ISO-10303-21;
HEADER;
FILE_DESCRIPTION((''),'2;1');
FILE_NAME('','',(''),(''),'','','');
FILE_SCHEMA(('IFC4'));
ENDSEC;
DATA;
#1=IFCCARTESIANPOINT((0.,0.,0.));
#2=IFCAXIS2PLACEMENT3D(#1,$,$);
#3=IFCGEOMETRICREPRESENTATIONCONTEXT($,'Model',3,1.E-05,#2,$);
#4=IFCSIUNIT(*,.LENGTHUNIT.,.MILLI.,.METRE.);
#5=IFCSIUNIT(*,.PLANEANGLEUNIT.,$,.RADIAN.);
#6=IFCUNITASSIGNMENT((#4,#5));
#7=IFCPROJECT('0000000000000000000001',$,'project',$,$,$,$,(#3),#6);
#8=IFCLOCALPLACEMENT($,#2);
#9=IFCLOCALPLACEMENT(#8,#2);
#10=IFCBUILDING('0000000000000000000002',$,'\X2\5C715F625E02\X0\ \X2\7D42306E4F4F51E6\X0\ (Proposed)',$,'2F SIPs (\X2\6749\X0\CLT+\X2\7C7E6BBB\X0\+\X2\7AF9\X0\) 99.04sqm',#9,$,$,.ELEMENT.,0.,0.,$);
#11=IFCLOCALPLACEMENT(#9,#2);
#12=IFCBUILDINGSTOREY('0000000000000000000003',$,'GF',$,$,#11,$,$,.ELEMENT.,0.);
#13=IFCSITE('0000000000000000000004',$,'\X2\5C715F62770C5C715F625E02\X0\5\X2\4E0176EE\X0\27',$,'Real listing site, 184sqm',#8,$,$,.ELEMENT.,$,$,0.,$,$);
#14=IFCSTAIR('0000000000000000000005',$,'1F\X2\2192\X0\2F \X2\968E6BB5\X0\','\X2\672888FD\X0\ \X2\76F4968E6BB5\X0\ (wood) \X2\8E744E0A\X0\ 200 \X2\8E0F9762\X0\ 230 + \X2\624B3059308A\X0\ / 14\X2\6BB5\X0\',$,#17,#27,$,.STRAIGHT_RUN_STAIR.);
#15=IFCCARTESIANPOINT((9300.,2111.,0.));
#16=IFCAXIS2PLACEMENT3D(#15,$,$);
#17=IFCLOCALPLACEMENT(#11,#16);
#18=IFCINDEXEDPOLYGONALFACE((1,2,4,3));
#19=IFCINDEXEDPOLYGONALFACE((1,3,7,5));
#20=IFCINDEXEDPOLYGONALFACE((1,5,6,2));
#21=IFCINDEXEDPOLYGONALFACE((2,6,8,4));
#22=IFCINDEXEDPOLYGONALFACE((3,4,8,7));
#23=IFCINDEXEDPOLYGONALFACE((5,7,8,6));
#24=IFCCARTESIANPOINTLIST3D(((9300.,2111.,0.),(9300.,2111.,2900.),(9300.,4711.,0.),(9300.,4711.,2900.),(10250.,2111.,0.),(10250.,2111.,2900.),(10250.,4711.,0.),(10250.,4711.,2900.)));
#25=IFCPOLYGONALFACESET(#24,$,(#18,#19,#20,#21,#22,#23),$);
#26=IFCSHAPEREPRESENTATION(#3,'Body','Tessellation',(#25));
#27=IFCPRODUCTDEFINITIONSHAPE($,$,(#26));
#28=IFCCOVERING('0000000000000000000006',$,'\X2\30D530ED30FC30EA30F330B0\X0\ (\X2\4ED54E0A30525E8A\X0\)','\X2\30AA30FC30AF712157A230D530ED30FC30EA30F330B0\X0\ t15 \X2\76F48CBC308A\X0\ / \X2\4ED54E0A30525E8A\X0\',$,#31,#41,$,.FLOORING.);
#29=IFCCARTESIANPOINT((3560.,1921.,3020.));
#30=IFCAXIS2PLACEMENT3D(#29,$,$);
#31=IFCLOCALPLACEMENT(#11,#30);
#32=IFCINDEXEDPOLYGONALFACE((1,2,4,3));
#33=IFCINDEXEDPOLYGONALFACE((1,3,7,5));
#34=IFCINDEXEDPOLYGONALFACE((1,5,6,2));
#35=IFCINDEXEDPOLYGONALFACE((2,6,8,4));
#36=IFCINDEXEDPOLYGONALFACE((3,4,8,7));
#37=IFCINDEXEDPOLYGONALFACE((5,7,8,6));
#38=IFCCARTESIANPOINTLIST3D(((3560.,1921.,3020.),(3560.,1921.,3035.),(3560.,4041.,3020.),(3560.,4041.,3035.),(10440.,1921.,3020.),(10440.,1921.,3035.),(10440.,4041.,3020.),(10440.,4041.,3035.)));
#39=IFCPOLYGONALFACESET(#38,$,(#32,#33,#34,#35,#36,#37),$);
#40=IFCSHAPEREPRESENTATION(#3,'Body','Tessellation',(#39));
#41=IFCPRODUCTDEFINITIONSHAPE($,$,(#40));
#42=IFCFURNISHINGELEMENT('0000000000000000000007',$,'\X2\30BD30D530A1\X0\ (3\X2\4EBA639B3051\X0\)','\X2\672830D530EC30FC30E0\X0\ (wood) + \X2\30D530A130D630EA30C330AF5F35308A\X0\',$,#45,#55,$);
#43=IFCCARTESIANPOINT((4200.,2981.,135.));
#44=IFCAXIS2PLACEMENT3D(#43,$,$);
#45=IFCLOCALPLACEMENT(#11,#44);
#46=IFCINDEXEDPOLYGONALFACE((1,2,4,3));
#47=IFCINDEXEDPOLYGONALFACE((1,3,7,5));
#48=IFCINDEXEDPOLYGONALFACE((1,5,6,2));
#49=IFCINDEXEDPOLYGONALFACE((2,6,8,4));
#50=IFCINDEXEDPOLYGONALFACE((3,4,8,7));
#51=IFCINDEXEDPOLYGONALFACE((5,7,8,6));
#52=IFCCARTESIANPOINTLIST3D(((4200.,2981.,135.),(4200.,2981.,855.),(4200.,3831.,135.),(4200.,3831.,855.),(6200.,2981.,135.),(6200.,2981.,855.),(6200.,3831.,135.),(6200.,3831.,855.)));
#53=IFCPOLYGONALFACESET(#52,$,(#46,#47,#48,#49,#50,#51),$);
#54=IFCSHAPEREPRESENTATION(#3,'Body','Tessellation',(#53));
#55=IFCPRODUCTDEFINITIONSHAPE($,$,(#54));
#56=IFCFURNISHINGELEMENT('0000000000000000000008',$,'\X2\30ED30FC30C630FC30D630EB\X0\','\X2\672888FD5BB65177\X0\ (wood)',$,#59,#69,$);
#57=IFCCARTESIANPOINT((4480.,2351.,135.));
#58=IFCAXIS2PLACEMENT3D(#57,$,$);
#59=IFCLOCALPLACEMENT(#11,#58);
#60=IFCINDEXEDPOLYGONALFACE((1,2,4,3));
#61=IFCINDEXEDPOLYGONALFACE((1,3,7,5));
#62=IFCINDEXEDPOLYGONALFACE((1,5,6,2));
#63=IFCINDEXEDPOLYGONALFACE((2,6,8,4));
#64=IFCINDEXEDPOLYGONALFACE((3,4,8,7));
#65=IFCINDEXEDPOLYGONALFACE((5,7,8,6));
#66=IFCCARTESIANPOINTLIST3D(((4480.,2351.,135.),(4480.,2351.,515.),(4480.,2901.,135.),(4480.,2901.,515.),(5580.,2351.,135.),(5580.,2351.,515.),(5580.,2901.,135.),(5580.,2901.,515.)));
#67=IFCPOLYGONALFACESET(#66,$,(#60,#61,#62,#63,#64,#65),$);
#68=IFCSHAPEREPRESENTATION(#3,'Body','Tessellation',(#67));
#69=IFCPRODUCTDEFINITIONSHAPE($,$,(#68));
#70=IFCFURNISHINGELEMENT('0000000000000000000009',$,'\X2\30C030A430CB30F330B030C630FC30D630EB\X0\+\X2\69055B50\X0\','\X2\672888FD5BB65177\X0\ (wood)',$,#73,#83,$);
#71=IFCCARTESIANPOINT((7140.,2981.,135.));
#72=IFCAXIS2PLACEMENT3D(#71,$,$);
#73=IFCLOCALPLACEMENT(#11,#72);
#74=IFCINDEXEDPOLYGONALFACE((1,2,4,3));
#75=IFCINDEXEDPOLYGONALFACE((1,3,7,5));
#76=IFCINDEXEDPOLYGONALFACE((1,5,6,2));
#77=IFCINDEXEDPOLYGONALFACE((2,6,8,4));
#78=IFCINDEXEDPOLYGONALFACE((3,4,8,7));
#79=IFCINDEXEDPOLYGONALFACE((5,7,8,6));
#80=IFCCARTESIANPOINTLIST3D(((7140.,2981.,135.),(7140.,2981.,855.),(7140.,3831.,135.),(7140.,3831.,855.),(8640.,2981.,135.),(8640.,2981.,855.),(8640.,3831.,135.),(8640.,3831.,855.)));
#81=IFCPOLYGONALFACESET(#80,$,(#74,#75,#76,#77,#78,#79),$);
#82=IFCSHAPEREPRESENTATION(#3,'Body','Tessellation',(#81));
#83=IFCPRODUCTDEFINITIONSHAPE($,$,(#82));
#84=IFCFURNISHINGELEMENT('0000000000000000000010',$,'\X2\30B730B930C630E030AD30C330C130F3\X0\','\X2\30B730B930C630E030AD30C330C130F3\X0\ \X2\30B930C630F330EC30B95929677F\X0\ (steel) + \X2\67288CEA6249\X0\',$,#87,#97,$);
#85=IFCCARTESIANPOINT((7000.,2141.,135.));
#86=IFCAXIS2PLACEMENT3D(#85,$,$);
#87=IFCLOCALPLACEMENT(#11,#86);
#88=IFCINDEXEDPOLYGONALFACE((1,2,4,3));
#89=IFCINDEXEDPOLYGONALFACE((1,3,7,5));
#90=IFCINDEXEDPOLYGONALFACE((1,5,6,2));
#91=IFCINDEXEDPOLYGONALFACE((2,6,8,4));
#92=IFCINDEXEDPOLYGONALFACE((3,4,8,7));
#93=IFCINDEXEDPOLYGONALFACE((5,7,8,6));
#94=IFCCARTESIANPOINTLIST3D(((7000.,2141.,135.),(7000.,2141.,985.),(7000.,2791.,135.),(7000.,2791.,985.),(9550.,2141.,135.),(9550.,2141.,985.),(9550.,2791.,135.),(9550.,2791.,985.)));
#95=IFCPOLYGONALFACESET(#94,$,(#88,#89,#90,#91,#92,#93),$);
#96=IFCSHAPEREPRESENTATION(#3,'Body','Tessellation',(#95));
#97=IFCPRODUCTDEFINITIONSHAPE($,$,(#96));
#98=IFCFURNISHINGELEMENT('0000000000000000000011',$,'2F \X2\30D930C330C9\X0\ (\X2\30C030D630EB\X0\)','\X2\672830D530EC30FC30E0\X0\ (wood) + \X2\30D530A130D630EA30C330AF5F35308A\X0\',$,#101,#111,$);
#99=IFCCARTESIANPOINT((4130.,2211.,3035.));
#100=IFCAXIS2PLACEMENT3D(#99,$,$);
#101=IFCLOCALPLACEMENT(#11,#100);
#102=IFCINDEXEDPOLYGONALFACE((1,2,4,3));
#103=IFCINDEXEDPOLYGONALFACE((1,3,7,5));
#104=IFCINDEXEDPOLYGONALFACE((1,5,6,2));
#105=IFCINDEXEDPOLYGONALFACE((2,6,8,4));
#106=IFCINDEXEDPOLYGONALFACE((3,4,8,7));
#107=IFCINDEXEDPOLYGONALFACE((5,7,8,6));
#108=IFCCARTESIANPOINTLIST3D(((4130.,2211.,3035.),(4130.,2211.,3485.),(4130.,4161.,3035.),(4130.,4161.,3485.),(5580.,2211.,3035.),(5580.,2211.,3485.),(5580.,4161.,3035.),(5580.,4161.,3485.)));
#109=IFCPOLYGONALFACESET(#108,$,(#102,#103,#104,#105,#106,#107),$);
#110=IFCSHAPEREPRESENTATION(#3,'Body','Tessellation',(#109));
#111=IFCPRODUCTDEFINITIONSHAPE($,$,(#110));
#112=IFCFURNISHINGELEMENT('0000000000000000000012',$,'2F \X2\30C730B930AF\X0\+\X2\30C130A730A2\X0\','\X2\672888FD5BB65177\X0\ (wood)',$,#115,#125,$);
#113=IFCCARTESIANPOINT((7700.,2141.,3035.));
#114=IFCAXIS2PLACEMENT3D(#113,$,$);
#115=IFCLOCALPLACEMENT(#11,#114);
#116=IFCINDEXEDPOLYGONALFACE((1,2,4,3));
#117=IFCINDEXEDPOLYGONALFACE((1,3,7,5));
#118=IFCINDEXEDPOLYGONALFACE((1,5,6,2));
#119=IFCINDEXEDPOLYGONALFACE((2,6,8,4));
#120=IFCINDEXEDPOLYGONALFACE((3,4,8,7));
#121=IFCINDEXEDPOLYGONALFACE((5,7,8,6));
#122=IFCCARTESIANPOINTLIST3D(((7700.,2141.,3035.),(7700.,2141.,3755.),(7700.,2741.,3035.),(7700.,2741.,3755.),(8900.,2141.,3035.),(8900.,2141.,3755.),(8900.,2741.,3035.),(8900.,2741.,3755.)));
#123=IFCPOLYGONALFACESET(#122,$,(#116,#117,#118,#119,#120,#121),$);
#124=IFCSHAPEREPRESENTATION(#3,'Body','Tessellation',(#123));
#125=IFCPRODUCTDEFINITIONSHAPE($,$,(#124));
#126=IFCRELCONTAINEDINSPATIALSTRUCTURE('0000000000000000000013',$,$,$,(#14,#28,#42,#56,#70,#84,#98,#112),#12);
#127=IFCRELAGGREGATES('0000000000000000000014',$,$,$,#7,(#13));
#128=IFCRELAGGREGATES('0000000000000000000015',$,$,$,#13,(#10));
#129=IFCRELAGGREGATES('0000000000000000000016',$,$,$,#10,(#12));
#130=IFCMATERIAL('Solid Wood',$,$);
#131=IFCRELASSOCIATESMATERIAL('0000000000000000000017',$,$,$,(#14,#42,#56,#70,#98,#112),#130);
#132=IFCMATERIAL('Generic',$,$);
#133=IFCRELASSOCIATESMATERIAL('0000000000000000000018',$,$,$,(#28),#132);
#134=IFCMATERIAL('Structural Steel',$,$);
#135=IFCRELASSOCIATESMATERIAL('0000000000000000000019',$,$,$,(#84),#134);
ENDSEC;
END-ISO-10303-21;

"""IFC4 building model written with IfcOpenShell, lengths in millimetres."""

from ifc_helpers import new_model, si_unit, frame, frame_2d, origin, place, context, project, spatial, rectangle, extrude, material, element, save


model = new_model("IFC4")

# Units and contexts
model_context = context("Model", 3, precision=1e-05, world=origin())
ifc_project = project(units=[si_unit("LENGTHUNIT", "METRE", prefix="MILLI"), si_unit("PLANEANGLEUNIT", "RADIAN")], contexts=[model_context])

# Site, building, storey
site_placement = place(None, origin())
site = spatial("IfcSite", under=ifc_project, at=site_placement, Name="山形県山形市5丁目27", ObjectType="Real listing site, 184sqm", CompositionType="ELEMENT", RefElevation=0.0)
building_placement = place(site_placement, origin())
building = spatial("IfcBuilding", under=site, at=building_placement, Name="山形市 終の住処 (Proposed)", ObjectType="2F SIPs (杉CLT+籾殻+竹) 99.04sqm", CompositionType="ELEMENT", ElevationOfRefHeight=0.0, ElevationOfTerrain=0.0)
storey_placement = place(building_placement, origin())
storey = spatial("IfcBuildingStorey", under=building, at=storey_placement, Name="GF", CompositionType="ELEMENT", Elevation=0.0)

# Shared definitions
ifc_material_1 = material(Name="Solid Wood")

# Shared definitions
ifc_material_2 = material(Name="Generic")

# Stair
stair_placement = place(storey_placement, frame((9300.0, 2111.0, 0.0)))
element("IfcStair", 1, at=stair_placement, inside=storey, material=ifc_material_1, Name="1F→2F 階段", Description="木製 直階段 (wood) 蹴上 200 踏面 230 + 手すり / 14段", PredefinedType="STRAIGHT_RUN_STAIR", context=model_context, shape_type="SweptSolid", body=[
    extrude(rectangle(XDim=950.0, YDim=2600.0, at=frame_2d((475.0, 1300.0))), frame((9300.0, 2111.0, 0.0)), (0.0, 0.0, 1.0), 2900.0),
])

# Covering
covering_placement = place(storey_placement, frame((3560.0, 1921.0, 3020.0)))
element("IfcCovering", 2, at=covering_placement, inside=storey, material=ifc_material_2, Name="フローリング (仕上げ床)", Description="オーク無垢フローリング t15 直貼り / 仕上げ床", PredefinedType="FLOORING", context=model_context, shape_type="SweptSolid", body=[
    extrude(rectangle(XDim=6880.0, YDim=2120.0, at=frame_2d((3440.0, 1060.0))), frame((3560.0, 1921.0, 3020.0)), (0.0, 0.0, 1.0), 15.0),
])

# Furnishing elements
furnishing_1_placement = place(storey_placement, frame((4200.0, 2981.0, 135.0)))
element("IfcFurnishingElement", 3, at=furnishing_1_placement, inside=storey, material=ifc_material_1, Name="ソファ (3人掛け)", Description="木フレーム (wood) + ファブリック張り", context=model_context, shape_type="SweptSolid", body=[
    extrude(rectangle(XDim=2000.0, YDim=850.0, at=frame_2d((1000.0, 425.0))), frame((4200.0, 2981.0, 135.0)), (0.0, 0.0, 1.0), 720.0),
])
furnishing_2_placement = place(storey_placement, frame((4480.0, 2351.0, 135.0)))
element("IfcFurnishingElement", 4, at=furnishing_2_placement, inside=storey, material=ifc_material_1, Name="ローテーブル", Description="木製家具 (wood)", context=model_context, shape_type="SweptSolid", body=[
    extrude(rectangle(XDim=1100.0, YDim=550.0, at=frame_2d((550.0, 275.0))), frame((4480.0, 2351.0, 135.0)), (0.0, 0.0, 1.0), 380.0),
])
furnishing_3_placement = place(storey_placement, frame((7140.0, 2981.0, 135.0)))
element("IfcFurnishingElement", 5, at=furnishing_3_placement, inside=storey, material=ifc_material_1, Name="ダイニングテーブル+椅子", Description="木製家具 (wood)", context=model_context, shape_type="SweptSolid", body=[
    extrude(rectangle(XDim=1500.0, YDim=850.0, at=frame_2d((750.0, 425.0))), frame((7140.0, 2981.0, 135.0)), (0.0, 0.0, 1.0), 720.0),
])
ifc_material_3 = material(Name="Structural Steel")
furnishing_4_placement = place(storey_placement, frame((7000.0, 2141.0, 135.0)))
element("IfcFurnishingElement", 6, at=furnishing_4_placement, inside=storey, material=ifc_material_3, Name="システムキッチン", Description="システムキッチン ステンレス天板 (steel) + 木質扉", context=model_context, shape_type="SweptSolid", body=[
    extrude(rectangle(XDim=2550.0, YDim=650.0, at=frame_2d((1275.0, 325.0))), frame((7000.0, 2141.0, 135.0)), (0.0, 0.0, 1.0), 850.0),
])
furnishing_5_placement = place(storey_placement, frame((4130.0, 2211.0, 3035.0)))
element("IfcFurnishingElement", 7, at=furnishing_5_placement, inside=storey, material=ifc_material_1, Name="2F ベッド (ダブル)", Description="木フレーム (wood) + ファブリック張り", context=model_context, shape_type="SweptSolid", body=[
    extrude(rectangle(XDim=1450.0, YDim=1950.0, at=frame_2d((725.0, 975.0))), frame((4130.0, 2211.0, 3035.0)), (0.0, 0.0, 1.0), 450.0),
])
furnishing_6_placement = place(storey_placement, frame((7700.0, 2141.0, 3035.0)))
element("IfcFurnishingElement", 8, at=furnishing_6_placement, inside=storey, material=ifc_material_1, Name="2F デスク+チェア", Description="木製家具 (wood)", context=model_context, shape_type="SweptSolid", body=[
    extrude(rectangle(XDim=1200.0, YDim=600.0, at=frame_2d((600.0, 300.0))), frame((7700.0, 2141.0, 3035.0)), (0.0, 0.0, 1.0), 720.0),
])

save(model, "model.ifc")
